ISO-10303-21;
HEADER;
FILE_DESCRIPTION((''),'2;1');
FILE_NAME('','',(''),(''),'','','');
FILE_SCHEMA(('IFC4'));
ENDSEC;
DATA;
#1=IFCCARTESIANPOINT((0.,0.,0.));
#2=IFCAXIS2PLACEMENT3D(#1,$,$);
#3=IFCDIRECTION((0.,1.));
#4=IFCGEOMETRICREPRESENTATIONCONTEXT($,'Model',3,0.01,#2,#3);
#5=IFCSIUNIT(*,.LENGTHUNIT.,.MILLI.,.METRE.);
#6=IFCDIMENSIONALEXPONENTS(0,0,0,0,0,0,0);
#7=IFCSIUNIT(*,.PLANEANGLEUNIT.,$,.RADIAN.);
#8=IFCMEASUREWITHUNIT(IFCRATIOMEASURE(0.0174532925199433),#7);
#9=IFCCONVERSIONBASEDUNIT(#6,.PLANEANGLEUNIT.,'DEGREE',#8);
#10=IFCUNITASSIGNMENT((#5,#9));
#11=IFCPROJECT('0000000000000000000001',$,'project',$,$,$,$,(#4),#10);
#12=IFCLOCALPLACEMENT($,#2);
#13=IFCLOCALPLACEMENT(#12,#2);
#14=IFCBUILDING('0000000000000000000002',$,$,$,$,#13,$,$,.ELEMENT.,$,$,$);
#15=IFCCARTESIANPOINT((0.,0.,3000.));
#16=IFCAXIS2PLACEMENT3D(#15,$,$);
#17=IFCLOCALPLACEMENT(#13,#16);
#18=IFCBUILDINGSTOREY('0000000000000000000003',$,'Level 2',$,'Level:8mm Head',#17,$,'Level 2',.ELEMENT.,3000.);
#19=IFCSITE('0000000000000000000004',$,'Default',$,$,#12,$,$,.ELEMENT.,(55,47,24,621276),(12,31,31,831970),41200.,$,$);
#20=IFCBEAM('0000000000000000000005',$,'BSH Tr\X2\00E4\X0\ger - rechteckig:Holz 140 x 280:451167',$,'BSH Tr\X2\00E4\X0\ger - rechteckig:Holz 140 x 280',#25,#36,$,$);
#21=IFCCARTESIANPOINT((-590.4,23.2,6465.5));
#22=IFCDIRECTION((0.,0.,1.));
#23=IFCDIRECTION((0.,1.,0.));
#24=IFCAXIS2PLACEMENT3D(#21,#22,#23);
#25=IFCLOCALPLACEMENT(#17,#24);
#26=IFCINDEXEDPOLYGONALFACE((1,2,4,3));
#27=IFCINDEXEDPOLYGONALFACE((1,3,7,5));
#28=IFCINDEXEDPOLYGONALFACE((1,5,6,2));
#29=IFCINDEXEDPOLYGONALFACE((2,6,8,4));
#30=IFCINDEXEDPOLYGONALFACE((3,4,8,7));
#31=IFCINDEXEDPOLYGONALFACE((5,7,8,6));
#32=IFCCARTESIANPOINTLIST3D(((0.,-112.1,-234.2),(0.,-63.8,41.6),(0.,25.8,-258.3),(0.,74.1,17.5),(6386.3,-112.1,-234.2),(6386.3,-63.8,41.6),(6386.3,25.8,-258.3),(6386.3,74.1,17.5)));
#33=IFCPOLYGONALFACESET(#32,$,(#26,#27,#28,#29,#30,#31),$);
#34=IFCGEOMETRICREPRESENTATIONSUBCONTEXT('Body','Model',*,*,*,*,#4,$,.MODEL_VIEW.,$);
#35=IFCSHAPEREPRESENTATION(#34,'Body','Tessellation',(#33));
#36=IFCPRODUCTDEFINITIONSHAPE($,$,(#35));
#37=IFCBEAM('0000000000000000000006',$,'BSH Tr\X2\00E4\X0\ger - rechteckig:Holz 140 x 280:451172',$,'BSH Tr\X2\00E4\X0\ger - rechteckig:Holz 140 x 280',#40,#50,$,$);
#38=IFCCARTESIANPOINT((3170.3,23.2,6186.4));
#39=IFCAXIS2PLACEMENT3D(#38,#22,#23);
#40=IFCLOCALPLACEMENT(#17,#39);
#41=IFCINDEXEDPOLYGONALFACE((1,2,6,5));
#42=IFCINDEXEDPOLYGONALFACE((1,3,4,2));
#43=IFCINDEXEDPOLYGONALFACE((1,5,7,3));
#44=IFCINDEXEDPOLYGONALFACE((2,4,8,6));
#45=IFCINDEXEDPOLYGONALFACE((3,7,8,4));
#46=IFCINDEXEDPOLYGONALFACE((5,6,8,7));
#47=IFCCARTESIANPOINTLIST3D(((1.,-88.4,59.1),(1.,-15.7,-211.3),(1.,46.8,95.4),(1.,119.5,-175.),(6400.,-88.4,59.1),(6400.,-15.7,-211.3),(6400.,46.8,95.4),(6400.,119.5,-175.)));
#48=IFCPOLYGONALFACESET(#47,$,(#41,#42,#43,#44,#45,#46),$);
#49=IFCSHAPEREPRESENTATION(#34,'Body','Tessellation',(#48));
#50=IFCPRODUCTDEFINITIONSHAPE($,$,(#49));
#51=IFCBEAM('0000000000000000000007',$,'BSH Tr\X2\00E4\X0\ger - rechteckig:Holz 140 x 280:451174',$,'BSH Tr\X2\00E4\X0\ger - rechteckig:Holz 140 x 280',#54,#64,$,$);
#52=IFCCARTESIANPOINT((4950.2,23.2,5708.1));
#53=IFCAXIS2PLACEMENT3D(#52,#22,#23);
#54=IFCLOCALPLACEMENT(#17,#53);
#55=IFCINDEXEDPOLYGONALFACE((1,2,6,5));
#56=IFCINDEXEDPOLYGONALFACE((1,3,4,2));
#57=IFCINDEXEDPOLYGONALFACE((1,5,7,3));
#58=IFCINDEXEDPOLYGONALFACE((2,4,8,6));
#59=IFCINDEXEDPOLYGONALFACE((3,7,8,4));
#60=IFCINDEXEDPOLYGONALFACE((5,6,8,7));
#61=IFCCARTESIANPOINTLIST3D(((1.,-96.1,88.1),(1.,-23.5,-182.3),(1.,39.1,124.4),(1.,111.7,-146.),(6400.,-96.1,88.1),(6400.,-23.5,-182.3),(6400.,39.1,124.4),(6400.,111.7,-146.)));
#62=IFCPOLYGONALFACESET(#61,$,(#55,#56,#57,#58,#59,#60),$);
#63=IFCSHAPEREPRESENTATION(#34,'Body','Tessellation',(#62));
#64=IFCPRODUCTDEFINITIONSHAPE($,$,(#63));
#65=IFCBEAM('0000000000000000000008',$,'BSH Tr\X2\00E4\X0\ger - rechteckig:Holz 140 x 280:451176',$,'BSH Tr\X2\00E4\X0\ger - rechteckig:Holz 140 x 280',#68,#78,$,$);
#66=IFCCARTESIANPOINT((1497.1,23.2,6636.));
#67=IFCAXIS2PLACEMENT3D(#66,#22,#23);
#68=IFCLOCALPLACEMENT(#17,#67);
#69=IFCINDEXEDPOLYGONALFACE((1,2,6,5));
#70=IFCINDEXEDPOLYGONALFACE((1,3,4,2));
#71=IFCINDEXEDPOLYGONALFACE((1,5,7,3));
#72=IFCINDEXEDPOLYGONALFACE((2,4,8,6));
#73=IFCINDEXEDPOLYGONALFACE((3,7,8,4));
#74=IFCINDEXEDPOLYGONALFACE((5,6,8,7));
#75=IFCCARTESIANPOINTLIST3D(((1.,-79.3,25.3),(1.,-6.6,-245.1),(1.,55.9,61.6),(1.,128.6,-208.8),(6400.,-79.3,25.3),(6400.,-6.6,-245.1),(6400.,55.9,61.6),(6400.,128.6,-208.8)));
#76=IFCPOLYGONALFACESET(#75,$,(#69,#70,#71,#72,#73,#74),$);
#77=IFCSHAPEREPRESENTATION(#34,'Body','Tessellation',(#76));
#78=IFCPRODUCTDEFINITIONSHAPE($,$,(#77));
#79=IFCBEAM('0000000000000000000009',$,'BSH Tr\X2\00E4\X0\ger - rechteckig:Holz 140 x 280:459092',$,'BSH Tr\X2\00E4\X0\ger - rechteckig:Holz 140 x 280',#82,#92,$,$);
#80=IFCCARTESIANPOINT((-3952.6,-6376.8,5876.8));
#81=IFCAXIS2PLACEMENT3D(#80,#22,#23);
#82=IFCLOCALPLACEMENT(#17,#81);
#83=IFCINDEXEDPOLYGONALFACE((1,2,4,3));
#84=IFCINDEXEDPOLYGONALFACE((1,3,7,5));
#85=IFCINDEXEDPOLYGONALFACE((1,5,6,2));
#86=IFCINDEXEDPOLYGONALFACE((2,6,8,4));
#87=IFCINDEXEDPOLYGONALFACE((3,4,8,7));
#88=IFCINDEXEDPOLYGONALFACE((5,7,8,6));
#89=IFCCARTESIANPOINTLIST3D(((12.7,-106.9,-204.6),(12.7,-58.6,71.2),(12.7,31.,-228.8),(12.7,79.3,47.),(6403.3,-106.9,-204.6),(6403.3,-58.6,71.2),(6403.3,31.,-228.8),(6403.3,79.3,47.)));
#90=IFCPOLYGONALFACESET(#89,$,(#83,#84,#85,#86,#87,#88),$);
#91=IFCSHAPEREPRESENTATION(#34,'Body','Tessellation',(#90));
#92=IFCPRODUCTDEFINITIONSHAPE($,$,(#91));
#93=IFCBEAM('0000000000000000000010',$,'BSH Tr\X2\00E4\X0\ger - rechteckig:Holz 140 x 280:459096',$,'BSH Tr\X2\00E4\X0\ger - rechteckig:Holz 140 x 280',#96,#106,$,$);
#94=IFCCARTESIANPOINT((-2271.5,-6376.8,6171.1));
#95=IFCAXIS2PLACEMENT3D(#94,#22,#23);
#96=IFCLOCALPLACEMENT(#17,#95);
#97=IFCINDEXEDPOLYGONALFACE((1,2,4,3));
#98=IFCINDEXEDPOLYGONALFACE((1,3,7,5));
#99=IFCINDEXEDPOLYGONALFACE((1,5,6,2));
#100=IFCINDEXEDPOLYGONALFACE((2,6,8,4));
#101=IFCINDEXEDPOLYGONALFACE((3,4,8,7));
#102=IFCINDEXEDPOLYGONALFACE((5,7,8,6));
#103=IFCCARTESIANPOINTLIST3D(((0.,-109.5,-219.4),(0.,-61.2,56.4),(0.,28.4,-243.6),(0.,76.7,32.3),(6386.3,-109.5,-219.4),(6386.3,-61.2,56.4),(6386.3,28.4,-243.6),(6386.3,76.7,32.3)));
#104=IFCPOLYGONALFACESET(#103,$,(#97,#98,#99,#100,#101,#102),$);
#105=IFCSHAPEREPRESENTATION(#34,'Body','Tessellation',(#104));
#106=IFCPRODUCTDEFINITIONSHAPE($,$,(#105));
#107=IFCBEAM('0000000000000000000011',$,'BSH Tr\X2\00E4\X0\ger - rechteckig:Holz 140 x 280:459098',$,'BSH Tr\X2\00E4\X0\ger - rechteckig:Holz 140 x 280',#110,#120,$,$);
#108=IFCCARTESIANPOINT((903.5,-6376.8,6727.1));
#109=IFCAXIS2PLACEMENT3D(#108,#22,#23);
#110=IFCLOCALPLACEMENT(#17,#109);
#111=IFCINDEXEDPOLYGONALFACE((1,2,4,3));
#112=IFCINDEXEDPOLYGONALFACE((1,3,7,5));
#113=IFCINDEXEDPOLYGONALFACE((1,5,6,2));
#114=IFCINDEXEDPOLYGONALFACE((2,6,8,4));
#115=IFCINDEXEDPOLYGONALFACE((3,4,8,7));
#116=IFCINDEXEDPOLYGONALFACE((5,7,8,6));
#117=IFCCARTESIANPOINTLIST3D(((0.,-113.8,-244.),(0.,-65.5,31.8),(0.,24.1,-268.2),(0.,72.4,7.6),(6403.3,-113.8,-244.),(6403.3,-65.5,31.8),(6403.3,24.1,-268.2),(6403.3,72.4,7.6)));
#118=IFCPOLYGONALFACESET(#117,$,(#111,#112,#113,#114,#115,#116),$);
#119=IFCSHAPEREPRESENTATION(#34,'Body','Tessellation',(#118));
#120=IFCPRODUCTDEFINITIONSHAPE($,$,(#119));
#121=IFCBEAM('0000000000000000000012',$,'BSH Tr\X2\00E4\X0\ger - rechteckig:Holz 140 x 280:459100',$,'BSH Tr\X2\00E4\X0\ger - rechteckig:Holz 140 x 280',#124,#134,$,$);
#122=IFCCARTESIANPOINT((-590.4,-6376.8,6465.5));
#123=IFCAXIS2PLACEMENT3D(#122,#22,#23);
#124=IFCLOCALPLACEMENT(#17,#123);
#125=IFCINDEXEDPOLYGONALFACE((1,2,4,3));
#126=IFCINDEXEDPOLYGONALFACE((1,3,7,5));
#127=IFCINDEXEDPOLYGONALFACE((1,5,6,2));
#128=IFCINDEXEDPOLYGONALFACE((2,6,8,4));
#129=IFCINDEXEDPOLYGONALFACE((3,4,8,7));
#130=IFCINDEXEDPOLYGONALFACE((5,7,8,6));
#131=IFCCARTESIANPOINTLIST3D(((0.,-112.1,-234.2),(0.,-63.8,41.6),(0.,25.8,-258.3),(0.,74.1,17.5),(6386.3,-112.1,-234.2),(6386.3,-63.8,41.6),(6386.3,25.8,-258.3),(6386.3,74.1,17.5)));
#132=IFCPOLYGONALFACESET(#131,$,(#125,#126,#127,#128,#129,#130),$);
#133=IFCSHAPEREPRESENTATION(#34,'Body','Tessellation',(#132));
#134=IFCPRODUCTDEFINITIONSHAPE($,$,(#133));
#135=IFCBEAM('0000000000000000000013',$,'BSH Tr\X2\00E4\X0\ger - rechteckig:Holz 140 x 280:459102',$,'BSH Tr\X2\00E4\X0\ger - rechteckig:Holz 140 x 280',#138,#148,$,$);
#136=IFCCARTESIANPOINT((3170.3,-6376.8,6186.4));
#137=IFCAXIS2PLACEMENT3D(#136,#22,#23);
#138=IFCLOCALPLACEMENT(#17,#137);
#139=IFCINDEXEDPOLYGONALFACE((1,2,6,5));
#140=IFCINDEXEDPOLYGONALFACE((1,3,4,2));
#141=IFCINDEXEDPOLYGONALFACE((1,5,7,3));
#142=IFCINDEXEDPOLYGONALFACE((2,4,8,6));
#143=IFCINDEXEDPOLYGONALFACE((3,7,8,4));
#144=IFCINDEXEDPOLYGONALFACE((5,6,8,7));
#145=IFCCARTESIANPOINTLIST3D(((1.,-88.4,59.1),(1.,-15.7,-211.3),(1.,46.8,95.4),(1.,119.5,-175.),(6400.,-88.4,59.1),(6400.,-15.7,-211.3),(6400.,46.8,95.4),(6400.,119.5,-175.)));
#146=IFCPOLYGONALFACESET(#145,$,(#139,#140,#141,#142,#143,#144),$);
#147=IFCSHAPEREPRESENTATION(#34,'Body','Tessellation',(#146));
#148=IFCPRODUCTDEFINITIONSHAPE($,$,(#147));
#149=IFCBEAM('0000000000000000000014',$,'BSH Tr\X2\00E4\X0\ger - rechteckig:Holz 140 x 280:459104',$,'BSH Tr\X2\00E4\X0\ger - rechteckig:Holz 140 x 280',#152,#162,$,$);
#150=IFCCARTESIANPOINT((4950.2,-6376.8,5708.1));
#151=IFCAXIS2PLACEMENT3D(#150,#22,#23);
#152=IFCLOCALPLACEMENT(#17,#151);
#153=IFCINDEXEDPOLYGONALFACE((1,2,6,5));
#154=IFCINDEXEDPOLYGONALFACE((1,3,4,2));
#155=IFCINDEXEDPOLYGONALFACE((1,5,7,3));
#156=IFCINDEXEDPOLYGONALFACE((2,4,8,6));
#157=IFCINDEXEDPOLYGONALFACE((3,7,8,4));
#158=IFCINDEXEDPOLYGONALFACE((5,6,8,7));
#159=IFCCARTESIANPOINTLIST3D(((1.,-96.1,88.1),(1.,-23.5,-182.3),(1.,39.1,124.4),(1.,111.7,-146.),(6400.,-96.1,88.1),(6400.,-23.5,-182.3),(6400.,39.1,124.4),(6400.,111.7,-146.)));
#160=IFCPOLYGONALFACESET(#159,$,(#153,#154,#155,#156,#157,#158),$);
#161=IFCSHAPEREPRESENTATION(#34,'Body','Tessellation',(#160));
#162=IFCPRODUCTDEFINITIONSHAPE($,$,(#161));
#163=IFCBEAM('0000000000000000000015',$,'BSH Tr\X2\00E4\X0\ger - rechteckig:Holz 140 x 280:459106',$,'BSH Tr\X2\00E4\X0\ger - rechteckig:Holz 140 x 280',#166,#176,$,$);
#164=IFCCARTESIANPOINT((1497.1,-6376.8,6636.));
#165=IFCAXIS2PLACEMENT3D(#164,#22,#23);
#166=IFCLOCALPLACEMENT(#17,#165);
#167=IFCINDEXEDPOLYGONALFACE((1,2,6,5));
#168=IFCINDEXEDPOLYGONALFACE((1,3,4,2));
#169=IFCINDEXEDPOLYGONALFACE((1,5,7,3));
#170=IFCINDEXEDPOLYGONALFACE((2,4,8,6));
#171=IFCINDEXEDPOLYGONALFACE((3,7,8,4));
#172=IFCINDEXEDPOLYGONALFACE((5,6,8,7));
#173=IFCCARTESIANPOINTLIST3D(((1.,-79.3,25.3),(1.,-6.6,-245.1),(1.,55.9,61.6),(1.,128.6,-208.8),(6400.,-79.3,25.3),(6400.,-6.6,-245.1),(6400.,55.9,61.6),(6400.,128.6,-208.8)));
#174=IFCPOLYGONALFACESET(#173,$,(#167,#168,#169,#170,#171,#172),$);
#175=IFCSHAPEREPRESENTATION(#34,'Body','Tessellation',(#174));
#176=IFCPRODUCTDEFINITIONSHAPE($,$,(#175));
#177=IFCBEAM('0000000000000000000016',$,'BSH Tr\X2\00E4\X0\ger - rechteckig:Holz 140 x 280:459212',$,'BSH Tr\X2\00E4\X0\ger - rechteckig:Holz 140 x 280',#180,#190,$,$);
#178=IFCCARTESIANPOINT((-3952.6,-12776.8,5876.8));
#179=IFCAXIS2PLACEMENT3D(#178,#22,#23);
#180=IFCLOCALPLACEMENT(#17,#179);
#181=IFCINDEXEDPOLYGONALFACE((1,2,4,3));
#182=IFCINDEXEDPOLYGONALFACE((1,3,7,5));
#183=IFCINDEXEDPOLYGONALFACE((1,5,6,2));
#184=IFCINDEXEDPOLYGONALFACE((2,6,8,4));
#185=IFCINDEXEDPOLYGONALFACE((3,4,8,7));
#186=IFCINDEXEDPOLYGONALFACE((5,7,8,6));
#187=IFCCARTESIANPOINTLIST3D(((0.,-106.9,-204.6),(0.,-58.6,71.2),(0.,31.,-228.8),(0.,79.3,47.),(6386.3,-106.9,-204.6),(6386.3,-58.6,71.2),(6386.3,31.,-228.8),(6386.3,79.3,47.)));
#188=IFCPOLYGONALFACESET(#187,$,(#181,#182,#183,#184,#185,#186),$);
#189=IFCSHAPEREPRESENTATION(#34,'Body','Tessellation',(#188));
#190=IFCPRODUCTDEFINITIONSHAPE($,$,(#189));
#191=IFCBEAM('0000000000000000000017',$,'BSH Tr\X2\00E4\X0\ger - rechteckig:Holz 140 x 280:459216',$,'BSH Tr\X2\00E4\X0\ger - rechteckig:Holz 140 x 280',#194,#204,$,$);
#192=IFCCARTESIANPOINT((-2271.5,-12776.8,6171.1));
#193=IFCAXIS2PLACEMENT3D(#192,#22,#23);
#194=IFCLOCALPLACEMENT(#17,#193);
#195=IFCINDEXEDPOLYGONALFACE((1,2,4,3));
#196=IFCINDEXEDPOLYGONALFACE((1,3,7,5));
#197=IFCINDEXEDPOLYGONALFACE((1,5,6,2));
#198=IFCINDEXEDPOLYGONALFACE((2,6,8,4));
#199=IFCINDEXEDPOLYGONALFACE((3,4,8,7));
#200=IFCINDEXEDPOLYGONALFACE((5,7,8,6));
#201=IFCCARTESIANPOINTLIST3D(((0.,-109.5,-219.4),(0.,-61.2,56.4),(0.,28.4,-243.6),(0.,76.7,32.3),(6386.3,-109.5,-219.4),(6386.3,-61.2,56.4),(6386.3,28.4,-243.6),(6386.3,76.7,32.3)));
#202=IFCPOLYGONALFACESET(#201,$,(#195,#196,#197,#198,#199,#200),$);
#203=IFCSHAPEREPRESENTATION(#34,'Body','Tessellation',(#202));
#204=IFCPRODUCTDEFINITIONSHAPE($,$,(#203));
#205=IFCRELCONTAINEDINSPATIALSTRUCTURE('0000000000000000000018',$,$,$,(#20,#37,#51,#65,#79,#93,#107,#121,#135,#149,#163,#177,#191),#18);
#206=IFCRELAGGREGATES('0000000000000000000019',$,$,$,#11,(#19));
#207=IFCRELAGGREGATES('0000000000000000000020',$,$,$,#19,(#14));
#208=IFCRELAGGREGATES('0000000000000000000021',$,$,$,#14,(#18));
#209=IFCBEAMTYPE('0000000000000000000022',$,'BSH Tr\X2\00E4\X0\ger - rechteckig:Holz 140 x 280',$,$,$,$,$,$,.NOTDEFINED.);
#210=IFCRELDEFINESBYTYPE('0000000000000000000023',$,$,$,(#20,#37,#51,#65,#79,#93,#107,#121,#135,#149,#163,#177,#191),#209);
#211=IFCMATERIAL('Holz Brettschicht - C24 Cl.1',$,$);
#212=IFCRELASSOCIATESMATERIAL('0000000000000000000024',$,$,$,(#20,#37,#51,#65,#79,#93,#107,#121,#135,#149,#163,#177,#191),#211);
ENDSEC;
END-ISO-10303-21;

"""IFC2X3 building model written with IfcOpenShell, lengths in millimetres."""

from ifc_helpers import new_model, entity, si_unit, converted_unit, direction, frame, frame_2d, origin, origin_2d_with_axis, place, context, subcontext, project, spatial, rectangle, extrude, material, type_object, element, save


model = new_model("IFC2X3")

# Units and contexts
model_context = context("Model", 3, precision=0.01, world=origin(), true_north=direction((0.0, 1.0)))
body_context = subcontext(model_context, "Body", "Model", "MODEL_VIEW")
ifc_project = project(units=[si_unit("LENGTHUNIT", "METRE", prefix="MILLI"), converted_unit("PLANEANGLEUNIT", "DEGREE", entity("IfcRatioMeasure", 0.0174532925199433), si_unit("PLANEANGLEUNIT", "RADIAN"), dimensions=[0, 0, 0, 0, 0, 0, 0])], contexts=[model_context])

# Site, building, storey
site_placement = place(None, origin())
site = spatial("IfcSite", under=ifc_project, at=site_placement, Name="Default", CompositionType="ELEMENT", RefLatitude=(55, 47, 24, 621276), RefLongitude=(12, 31, 31, 831970), RefElevation=41200.0)
building_placement = place(site_placement, origin())
building = spatial("IfcBuilding", under=site, at=building_placement, CompositionType="ELEMENT")
storey_placement = place(building_placement, frame((0.0, 0.0, 3000.0)))
storey = spatial("IfcBuildingStorey", under=building, at=storey_placement, Name="Level 2", ObjectType="Level:8mm Head", LongName="Level 2", CompositionType="ELEMENT", Elevation=3000.0)

# Beams
ifc_material = material(Name="Holz Brettschicht - C24 Cl.1")
beam_type_1 = type_object("IfcBeamType", Name="BSH Träger - rechteckig:Holz 140 x 280", PredefinedType="NOTDEFINED")
beam_1_placement = place(storey_placement, frame((-590.4, 23.2, 6465.5), z_axis=(0.0, 0.0, 1.0), x_axis=(0.0, 1.0, 0.0)))
element("IfcBeam", 1, at=beam_1_placement, inside=storey, type_object=beam_type_1, material=ifc_material, Name="BSH Träger - rechteckig:Holz 140 x 280:451167", ObjectType="BSH Träger - rechteckig:Holz 140 x 280", context=body_context, shape_type="SweptSolid", body=[
    extrude(rectangle(XDim=280.0, YDim=140.0, at=frame_2d((0.0, 0.0), x_axis=(1.0, 0.0))), frame((0.0, -19.0, -108.4), z_axis=(1.0, 0.0, 0.0), x_axis=(0.0, 0.172491, 0.985011)), (0.0, 0.0, 1.0), 6386.3),
])
beam_2_placement = place(storey_placement, frame((3170.3, 23.2, 6186.4), z_axis=(0.0, 0.0, 1.0), x_axis=(0.0, 1.0, 0.0)))
element("IfcBeam", 2, at=beam_2_placement, inside=storey, type_object=beam_type_1, material=ifc_material, Name="BSH Träger - rechteckig:Holz 140 x 280:451172", ObjectType="BSH Träger - rechteckig:Holz 140 x 280", context=body_context, shape_type="SweptSolid", body=[
    extrude(rectangle(XDim=280.0, YDim=140.0, at=frame_2d((0.0, 0.0), x_axis=(1.0, 0.0))), frame((1.0, 15.6, -57.9), z_axis=(1.0, 0.0, 0.0), x_axis=(0.0, -0.259528, 0.965735)), (0.0, 0.0, 1.0), 6399.0),
])
beam_3_placement = place(storey_placement, frame((4950.2, 23.2, 5708.1), z_axis=(0.0, 0.0, 1.0), x_axis=(0.0, 1.0, 0.0)))
element("IfcBeam", 3, at=beam_3_placement, inside=storey, type_object=beam_type_1, material=ifc_material, Name="BSH Träger - rechteckig:Holz 140 x 280:451174", ObjectType="BSH Träger - rechteckig:Holz 140 x 280", context=body_context, shape_type="SweptSolid", body=[
    extrude(rectangle(XDim=280.0, YDim=140.0, at=frame_2d((0.0, 0.0), x_axis=(1.0, 0.0))), frame((1.0, 7.8, -29.0), z_axis=(1.0, 0.0, 0.0), x_axis=(0.0, -0.259528, 0.965735)), (0.0, 0.0, 1.0), 6399.0),
])
beam_4_placement = place(storey_placement, frame((1497.1, 23.2, 6636.0), z_axis=(0.0, 0.0, 1.0), x_axis=(0.0, 1.0, 0.0)))
element("IfcBeam", 4, at=beam_4_placement, inside=storey, type_object=beam_type_1, material=ifc_material, Name="BSH Träger - rechteckig:Holz 140 x 280:451176", ObjectType="BSH Träger - rechteckig:Holz 140 x 280", context=body_context, shape_type="SweptSolid", body=[
    extrude(rectangle(XDim=280.0, YDim=140.0, at=frame_2d((0.0, 0.0), x_axis=(1.0, 0.0))), frame((1.0, 24.7, -91.7), z_axis=(1.0, 0.0, 0.0), x_axis=(0.0, -0.259528, 0.965735)), (0.0, 0.0, 1.0), 6399.0),
])
beam_5_placement = place(storey_placement, frame((-3952.6, -6376.8, 5876.8), z_axis=(0.0, 0.0, 1.0), x_axis=(0.0, 1.0, 0.0)))
element("IfcBeam", 5, at=beam_5_placement, inside=storey, type_object=beam_type_1, material=ifc_material, Name="BSH Träger - rechteckig:Holz 140 x 280:459092", ObjectType="BSH Träger - rechteckig:Holz 140 x 280", context=body_context, shape_type="SweptSolid", body=[
    extrude(rectangle(XDim=280.0, YDim=140.0, at=origin_2d_with_axis()), frame((12.7, -13.8, -78.8), z_axis=(1.0, 0.0, 0.0), x_axis=(0.0, 0.172491, 0.985011)), (0.0, 0.0, 1.0), 6390.6),
])
beam_6_placement = place(storey_placement, frame((-2271.5, -6376.8, 6171.1), z_axis=(0.0, 0.0, 1.0), x_axis=(0.0, 1.0, 0.0)))
element("IfcBeam", 6, at=beam_6_placement, inside=storey, type_object=beam_type_1, material=ifc_material, Name="BSH Träger - rechteckig:Holz 140 x 280:459096", ObjectType="BSH Träger - rechteckig:Holz 140 x 280", context=body_context, shape_type="SweptSolid", body=[
    extrude(rectangle(XDim=280.0, YDim=140.0, at=frame_2d((0.0, 0.0), x_axis=(1.0, 0.0))), frame((0.0, -16.4, -93.6), z_axis=(1.0, 0.0, 0.0), x_axis=(0.0, 0.172491, 0.985011)), (0.0, 0.0, 1.0), 6386.3),
])
beam_7_placement = place(storey_placement, frame((903.5, -6376.8, 6727.1), z_axis=(0.0, 0.0, 1.0), x_axis=(0.0, 1.0, 0.0)))
element("IfcBeam", 7, at=beam_7_placement, inside=storey, type_object=beam_type_1, material=ifc_material, Name="BSH Träger - rechteckig:Holz 140 x 280:459098", ObjectType="BSH Träger - rechteckig:Holz 140 x 280", context=body_context, shape_type="SweptSolid", body=[
    extrude(rectangle(XDim=280.0, YDim=140.0, at=frame_2d((0.0, 0.0), x_axis=(1.0, 0.0))), frame((0.0, -20.7, -118.2), z_axis=(1.0, 0.0, 0.0), x_axis=(0.0, 0.172491, 0.985011)), (0.0, 0.0, 1.0), 6403.3),
])
beam_8_placement = place(storey_placement, frame((-590.4, -6376.8, 6465.5), z_axis=(0.0, 0.0, 1.0), x_axis=(0.0, 1.0, 0.0)))
element("IfcBeam", 8, at=beam_8_placement, inside=storey, type_object=beam_type_1, material=ifc_material, Name="BSH Träger - rechteckig:Holz 140 x 280:459100", ObjectType="BSH Träger - rechteckig:Holz 140 x 280", context=body_context, shape_type="SweptSolid", body=[
    extrude(rectangle(XDim=280.0, YDim=140.0, at=frame_2d((0.0, 0.0), x_axis=(1.0, 0.0))), frame((0.0, -19.0, -108.4), z_axis=(1.0, 0.0, 0.0), x_axis=(0.0, 0.172491, 0.985011)), (0.0, 0.0, 1.0), 6386.3),
])
beam_9_placement = place(storey_placement, frame((3170.3, -6376.8, 6186.4), z_axis=(0.0, 0.0, 1.0), x_axis=(0.0, 1.0, 0.0)))
element("IfcBeam", 9, at=beam_9_placement, inside=storey, type_object=beam_type_1, material=ifc_material, Name="BSH Träger - rechteckig:Holz 140 x 280:459102", ObjectType="BSH Träger - rechteckig:Holz 140 x 280", context=body_context, shape_type="SweptSolid", body=[
    extrude(rectangle(XDim=280.0, YDim=140.0, at=frame_2d((0.0, 0.0), x_axis=(1.0, 0.0))), frame((1.0, 15.6, -57.9), z_axis=(1.0, 0.0, 0.0), x_axis=(0.0, -0.259528, 0.965735)), (0.0, 0.0, 1.0), 6399.0),
])
beam_10_placement = place(storey_placement, frame((4950.2, -6376.8, 5708.1), z_axis=(0.0, 0.0, 1.0), x_axis=(0.0, 1.0, 0.0)))
element("IfcBeam", 10, at=beam_10_placement, inside=storey, type_object=beam_type_1, material=ifc_material, Name="BSH Träger - rechteckig:Holz 140 x 280:459104", ObjectType="BSH Träger - rechteckig:Holz 140 x 280", context=body_context, shape_type="SweptSolid", body=[
    extrude(rectangle(XDim=280.0, YDim=140.0, at=frame_2d((0.0, 0.0), x_axis=(1.0, 0.0))), frame((1.0, 7.8, -29.0), z_axis=(1.0, 0.0, 0.0), x_axis=(0.0, -0.259528, 0.965735)), (0.0, 0.0, 1.0), 6399.0),
])
beam_11_placement = place(storey_placement, frame((1497.1, -6376.8, 6636.0), z_axis=(0.0, 0.0, 1.0), x_axis=(0.0, 1.0, 0.0)))
element("IfcBeam", 11, at=beam_11_placement, inside=storey, type_object=beam_type_1, material=ifc_material, Name="BSH Träger - rechteckig:Holz 140 x 280:459106", ObjectType="BSH Träger - rechteckig:Holz 140 x 280", context=body_context, shape_type="SweptSolid", body=[
    extrude(rectangle(XDim=280.0, YDim=140.0, at=frame_2d((0.0, 0.0), x_axis=(1.0, 0.0))), frame((1.0, 24.7, -91.7), z_axis=(1.0, 0.0, 0.0), x_axis=(0.0, -0.259528, 0.965735)), (0.0, 0.0, 1.0), 6399.0),
])
beam_12_placement = place(storey_placement, frame((-3952.6, -12776.8, 5876.8), z_axis=(0.0, 0.0, 1.0), x_axis=(0.0, 1.0, 0.0)))
element("IfcBeam", 12, at=beam_12_placement, inside=storey, type_object=beam_type_1, material=ifc_material, Name="BSH Träger - rechteckig:Holz 140 x 280:459212", ObjectType="BSH Träger - rechteckig:Holz 140 x 280", context=body_context, shape_type="SweptSolid", body=[
    extrude(rectangle(XDim=280.0, YDim=140.0, at=origin_2d_with_axis()), frame((0.0, -13.8, -78.8), z_axis=(1.0, 0.0, 0.0), x_axis=(0.0, 0.172491, 0.985011)), (0.0, 0.0, 1.0), 6386.3),
])
beam_13_placement = place(storey_placement, frame((-2271.5, -12776.8, 6171.1), z_axis=(0.0, 0.0, 1.0), x_axis=(0.0, 1.0, 0.0)))
element("IfcBeam", 13, at=beam_13_placement, inside=storey, type_object=beam_type_1, material=ifc_material, Name="BSH Träger - rechteckig:Holz 140 x 280:459216", ObjectType="BSH Träger - rechteckig:Holz 140 x 280", context=body_context, shape_type="SweptSolid", body=[
    extrude(rectangle(XDim=280.0, YDim=140.0, at=frame_2d((0.0, 0.0), x_axis=(1.0, 0.0))), frame((0.0, -16.4, -93.6), z_axis=(1.0, 0.0, 0.0), x_axis=(0.0, 0.172491, 0.985011)), (0.0, 0.0, 1.0), 6386.3),
])

save(model, "model.ifc")
